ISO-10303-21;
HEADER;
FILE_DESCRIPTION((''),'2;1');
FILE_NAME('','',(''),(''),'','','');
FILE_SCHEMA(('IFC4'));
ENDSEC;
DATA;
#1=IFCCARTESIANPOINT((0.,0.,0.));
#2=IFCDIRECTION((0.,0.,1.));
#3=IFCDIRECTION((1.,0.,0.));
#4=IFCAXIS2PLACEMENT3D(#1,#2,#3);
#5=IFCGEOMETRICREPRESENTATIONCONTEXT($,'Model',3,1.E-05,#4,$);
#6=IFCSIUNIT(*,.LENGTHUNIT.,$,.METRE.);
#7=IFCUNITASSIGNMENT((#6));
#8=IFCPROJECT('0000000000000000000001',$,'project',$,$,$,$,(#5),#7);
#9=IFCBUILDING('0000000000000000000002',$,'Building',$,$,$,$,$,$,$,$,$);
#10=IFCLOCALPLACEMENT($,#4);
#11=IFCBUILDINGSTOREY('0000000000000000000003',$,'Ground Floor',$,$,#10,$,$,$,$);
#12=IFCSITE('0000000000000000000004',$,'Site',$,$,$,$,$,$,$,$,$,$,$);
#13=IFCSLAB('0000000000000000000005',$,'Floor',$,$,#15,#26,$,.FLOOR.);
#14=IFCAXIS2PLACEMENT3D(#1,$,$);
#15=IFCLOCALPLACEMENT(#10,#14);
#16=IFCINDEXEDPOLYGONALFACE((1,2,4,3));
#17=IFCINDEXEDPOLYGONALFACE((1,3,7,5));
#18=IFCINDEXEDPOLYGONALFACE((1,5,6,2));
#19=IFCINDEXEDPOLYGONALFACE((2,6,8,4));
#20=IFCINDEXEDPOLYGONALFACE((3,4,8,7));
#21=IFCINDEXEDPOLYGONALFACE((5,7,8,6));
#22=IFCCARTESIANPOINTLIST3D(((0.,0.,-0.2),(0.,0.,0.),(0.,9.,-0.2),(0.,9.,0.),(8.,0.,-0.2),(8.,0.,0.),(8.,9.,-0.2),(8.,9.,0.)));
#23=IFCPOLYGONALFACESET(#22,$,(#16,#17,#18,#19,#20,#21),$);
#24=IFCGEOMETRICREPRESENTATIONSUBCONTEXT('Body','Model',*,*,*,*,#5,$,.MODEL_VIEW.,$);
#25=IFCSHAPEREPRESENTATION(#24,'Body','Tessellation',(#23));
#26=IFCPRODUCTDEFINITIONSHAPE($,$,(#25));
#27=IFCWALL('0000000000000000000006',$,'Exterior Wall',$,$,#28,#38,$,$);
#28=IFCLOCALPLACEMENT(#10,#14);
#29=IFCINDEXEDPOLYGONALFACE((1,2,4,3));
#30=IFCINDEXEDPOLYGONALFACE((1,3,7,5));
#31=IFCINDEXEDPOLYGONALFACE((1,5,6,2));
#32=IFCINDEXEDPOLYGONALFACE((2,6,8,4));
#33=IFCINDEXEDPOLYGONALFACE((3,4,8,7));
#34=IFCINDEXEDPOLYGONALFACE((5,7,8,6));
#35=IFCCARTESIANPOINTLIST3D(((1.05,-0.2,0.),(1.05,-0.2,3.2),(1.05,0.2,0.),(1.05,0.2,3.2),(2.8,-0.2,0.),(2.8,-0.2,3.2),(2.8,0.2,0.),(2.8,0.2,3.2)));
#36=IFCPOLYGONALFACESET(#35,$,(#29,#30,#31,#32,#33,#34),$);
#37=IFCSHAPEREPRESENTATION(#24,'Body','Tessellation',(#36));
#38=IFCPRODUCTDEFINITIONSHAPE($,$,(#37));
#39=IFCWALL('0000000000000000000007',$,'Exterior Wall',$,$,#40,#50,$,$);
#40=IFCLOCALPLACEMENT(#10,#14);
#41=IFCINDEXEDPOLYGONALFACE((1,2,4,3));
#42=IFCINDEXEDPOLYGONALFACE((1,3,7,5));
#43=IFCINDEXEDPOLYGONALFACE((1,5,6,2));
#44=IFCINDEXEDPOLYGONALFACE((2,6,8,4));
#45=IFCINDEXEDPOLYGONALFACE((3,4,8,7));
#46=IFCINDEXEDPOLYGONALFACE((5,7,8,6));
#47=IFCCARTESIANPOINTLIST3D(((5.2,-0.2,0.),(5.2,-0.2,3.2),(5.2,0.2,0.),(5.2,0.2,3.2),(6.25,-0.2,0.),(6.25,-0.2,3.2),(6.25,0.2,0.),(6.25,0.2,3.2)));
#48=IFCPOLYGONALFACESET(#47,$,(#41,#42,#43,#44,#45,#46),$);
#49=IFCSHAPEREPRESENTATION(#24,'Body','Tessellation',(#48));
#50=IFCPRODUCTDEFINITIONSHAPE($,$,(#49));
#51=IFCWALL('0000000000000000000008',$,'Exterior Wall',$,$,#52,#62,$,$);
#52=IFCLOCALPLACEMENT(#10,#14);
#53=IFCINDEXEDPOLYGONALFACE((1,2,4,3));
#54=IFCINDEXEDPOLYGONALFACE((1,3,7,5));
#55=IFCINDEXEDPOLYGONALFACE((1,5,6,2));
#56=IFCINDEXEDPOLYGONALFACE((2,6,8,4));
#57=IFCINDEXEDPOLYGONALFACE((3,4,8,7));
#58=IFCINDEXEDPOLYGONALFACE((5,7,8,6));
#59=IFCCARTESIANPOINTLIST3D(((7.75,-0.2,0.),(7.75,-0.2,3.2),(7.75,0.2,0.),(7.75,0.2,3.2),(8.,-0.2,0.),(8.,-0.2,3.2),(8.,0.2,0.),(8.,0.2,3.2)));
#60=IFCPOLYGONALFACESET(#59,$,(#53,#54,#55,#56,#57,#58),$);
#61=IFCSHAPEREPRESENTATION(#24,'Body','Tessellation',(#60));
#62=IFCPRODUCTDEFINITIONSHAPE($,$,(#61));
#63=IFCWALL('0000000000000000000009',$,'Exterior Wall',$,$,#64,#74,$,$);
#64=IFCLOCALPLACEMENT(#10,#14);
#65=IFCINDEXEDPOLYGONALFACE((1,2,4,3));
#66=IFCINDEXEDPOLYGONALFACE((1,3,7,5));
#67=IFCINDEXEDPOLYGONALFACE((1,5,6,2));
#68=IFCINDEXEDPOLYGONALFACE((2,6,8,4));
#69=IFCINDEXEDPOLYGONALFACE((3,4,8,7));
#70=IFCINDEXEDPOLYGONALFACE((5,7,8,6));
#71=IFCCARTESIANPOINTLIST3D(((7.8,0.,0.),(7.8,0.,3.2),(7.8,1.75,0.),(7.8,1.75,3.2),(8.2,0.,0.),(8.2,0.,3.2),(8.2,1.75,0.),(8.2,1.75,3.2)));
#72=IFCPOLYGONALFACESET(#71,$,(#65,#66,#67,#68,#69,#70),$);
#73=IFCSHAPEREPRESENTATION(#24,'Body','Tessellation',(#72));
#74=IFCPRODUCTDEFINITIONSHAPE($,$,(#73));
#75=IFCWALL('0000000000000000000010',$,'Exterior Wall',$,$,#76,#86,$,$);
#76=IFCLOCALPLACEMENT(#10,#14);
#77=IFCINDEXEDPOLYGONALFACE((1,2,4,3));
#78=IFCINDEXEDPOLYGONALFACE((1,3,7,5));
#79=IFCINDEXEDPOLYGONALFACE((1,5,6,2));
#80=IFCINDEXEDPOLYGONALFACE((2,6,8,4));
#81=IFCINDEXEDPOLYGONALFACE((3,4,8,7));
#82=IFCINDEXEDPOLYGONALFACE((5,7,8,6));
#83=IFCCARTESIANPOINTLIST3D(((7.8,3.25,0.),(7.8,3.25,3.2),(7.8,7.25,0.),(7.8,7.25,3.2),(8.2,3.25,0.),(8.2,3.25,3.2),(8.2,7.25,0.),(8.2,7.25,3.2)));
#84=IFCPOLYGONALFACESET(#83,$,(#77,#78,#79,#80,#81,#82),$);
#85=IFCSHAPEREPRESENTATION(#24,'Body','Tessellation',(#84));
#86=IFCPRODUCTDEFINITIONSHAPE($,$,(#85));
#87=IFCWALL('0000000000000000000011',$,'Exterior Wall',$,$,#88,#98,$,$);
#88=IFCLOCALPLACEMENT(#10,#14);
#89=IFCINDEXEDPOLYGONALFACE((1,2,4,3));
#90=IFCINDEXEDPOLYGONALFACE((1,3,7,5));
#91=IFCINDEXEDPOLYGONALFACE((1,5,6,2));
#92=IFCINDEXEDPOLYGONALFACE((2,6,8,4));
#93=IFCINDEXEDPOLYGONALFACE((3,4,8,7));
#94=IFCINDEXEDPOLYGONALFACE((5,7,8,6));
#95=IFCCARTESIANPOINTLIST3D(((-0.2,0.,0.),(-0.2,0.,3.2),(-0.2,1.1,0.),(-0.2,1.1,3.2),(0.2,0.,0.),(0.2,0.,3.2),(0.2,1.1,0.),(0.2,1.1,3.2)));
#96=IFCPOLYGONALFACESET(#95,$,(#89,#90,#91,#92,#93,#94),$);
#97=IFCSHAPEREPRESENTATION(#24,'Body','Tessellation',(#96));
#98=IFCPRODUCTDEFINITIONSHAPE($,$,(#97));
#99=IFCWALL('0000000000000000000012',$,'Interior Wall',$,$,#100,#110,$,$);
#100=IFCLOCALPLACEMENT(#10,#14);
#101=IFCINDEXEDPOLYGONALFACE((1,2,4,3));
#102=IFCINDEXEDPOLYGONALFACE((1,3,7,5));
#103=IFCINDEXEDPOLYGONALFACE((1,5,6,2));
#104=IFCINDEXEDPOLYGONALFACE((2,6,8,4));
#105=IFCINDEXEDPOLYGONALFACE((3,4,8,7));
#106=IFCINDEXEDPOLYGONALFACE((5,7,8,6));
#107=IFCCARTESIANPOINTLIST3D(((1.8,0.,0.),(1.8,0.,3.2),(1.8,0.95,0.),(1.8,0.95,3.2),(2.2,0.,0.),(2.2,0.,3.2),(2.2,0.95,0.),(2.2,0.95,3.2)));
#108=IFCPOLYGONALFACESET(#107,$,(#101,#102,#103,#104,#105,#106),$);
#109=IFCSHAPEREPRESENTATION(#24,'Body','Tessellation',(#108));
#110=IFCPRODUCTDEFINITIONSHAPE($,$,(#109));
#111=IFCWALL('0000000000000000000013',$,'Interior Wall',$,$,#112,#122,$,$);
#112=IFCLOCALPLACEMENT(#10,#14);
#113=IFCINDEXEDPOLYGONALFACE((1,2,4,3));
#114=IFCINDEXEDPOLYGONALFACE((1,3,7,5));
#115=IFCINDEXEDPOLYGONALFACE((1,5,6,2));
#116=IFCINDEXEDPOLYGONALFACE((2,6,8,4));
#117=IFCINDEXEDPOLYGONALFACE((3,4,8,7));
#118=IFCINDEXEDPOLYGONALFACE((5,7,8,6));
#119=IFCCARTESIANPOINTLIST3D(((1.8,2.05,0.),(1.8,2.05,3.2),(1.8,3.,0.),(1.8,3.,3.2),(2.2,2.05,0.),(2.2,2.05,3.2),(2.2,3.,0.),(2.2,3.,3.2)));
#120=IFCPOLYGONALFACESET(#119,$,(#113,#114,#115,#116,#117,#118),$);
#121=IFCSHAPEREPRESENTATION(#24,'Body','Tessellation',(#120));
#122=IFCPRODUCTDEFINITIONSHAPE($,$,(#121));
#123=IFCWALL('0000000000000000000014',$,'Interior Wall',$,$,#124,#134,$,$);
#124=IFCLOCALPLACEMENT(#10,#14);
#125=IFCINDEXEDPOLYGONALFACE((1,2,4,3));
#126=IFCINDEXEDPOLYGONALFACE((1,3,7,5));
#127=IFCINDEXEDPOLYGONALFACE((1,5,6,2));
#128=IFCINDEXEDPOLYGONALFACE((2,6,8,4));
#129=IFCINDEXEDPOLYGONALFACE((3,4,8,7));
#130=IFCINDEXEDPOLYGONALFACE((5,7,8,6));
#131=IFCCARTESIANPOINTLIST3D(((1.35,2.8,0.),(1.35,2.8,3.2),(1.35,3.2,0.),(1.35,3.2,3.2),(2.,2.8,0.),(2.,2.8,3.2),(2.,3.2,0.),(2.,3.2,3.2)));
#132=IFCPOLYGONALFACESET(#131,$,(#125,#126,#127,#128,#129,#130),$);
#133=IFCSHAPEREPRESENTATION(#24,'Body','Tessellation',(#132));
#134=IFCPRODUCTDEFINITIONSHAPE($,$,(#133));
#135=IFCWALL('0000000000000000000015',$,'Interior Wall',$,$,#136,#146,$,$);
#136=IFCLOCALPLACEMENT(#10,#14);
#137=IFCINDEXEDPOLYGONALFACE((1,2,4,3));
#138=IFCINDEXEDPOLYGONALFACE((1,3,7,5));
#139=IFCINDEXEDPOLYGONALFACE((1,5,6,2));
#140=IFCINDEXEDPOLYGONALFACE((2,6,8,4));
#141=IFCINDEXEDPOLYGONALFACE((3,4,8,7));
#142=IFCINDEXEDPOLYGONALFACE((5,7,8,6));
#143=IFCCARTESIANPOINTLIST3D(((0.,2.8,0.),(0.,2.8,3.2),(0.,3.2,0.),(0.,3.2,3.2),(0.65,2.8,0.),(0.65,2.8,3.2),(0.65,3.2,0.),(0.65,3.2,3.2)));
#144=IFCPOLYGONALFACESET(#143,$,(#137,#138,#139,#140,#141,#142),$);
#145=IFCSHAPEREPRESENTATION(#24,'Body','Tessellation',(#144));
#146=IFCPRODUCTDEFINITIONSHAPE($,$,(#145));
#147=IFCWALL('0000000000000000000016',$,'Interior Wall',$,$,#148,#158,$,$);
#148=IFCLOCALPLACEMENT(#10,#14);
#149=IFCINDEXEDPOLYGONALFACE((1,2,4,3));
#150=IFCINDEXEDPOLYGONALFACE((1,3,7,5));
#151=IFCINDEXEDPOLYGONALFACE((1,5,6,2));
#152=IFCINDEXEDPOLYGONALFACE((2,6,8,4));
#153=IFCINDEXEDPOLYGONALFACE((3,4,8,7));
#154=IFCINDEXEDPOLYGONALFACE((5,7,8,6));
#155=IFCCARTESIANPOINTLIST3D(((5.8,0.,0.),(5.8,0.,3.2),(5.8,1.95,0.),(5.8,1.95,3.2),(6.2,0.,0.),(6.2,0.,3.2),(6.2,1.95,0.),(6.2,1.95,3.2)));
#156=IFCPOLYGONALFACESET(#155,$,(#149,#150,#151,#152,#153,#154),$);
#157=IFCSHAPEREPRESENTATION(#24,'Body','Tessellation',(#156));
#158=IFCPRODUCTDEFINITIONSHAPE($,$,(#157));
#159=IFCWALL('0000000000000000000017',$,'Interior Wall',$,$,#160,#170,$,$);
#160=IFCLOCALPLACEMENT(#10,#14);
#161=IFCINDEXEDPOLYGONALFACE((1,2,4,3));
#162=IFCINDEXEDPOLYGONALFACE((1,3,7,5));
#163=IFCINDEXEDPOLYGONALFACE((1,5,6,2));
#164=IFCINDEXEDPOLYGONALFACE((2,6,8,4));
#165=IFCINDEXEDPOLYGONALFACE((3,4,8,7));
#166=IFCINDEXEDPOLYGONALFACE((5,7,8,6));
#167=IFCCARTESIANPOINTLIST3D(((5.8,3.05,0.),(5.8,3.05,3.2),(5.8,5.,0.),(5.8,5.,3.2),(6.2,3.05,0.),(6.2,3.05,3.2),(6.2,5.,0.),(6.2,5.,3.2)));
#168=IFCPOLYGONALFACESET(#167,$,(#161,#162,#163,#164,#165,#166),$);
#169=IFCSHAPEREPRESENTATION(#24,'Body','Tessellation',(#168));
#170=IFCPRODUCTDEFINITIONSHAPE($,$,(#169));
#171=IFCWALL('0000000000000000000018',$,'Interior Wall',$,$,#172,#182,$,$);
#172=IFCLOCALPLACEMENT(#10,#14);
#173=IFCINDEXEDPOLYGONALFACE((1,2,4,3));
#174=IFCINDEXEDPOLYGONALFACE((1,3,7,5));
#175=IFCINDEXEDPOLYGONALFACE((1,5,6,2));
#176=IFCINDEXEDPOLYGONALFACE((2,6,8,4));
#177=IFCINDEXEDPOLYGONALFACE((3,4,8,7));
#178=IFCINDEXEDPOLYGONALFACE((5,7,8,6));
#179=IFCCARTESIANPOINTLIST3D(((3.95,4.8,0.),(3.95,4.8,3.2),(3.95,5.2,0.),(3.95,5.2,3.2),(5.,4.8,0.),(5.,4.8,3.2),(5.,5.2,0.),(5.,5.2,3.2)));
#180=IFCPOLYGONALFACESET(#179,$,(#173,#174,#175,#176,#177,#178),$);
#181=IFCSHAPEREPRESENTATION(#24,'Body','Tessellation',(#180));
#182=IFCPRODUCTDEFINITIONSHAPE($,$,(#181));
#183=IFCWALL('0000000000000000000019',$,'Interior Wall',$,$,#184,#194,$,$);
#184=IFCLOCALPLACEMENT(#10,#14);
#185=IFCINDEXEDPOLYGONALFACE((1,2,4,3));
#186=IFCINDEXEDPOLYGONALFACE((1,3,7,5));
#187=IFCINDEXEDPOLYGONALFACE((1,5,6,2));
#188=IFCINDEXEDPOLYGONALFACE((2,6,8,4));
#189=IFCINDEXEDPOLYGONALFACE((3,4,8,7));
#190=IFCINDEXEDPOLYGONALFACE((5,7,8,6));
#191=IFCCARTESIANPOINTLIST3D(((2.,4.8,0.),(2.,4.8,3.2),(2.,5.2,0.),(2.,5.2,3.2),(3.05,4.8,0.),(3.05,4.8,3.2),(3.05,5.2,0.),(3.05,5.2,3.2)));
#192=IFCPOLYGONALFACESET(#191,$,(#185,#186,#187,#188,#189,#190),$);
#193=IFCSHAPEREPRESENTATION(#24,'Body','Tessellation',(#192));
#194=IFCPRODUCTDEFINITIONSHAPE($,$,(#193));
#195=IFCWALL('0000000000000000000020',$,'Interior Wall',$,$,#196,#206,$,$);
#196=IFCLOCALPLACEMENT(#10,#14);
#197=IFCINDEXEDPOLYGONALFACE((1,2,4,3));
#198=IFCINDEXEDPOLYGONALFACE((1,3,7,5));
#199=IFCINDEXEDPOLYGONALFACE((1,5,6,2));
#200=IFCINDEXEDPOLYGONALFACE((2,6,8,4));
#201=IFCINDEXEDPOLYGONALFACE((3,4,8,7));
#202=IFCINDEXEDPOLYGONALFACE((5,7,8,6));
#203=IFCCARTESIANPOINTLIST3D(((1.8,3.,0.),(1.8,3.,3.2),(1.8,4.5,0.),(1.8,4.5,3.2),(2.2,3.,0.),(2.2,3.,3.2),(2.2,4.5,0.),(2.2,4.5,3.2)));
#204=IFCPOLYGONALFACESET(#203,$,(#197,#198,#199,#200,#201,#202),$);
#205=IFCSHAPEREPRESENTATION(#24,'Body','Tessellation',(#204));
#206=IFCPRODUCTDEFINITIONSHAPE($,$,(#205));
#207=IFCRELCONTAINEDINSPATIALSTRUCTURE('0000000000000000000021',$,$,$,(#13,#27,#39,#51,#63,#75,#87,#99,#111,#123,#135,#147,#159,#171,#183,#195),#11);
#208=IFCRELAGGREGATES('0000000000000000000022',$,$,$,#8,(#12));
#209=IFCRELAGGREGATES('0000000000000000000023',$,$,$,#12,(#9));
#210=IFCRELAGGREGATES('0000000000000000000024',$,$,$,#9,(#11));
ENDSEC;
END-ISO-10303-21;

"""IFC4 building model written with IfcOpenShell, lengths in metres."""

from ifc_helpers import new_model, si_unit, frame, origin_with_axes, place, context, subcontext, project, spatial, indexed_curve, outline, extrude, element, save


model = new_model("IFC4")

# Units and contexts
model_context = context("Model", 3, precision=1e-05, world=origin_with_axes())
body_context = subcontext(model_context, "Body", "Model", "MODEL_VIEW")
ifc_project = project(units=[si_unit("LENGTHUNIT", "METRE")], contexts=[model_context])

# Site, building, storey
site = spatial("IfcSite", under=ifc_project, Name="Site")
building = spatial("IfcBuilding", under=site, Name="Building")
storey_placement = place(None, origin_with_axes())
storey = spatial("IfcBuildingStorey", under=building, at=storey_placement, Name="Ground Floor")

# Slab
slab_placement = place(storey_placement, frame((0.0, 0.0, -0.2), z_axis=(0.0, 0.0, 1.0), x_axis=(1.0, 0.0, 0.0)))
element("IfcSlab", 1, at=slab_placement, inside=storey, Name="Floor", PredefinedType="FLOOR", context=body_context, shape_type="SweptSolid", body=[
    extrude(outline(indexed_curve([(0.0, 0.0), (8.0, 0.0), (8.0, 9.0), (0.0, 9.0)])), None, (0.0, 0.0, 1.0), 0.2),
])

# Walls
wall_1_placement = place(storey_placement, frame((1.05, 0.0, 0.0), z_axis=(0.0, 0.0, 1.0), x_axis=(1.0, 0.0, 0.0)))
element("IfcWall", 2, at=wall_1_placement, inside=storey, Name="Exterior Wall", context=body_context, shape_type="SweptSolid", body=[
    extrude(outline(indexed_curve([(0.0, 0.0), (0.0, 0.4), (1.75, 0.4), (1.75, 0.0), (0.0, 0.0)], self_intersect=False)), frame((0.0, -0.2, 0.0), z_axis=(0.0, 0.0, 1.0), x_axis=(1.0, 0.0, 0.0)), (0.0, 0.0, 1.0), 3.2),
])
wall_2_placement = place(storey_placement, frame((5.2, 0.0, 0.0), z_axis=(0.0, 0.0, 1.0), x_axis=(1.0, 0.0, 0.0)))
element("IfcWall", 3, at=wall_2_placement, inside=storey, Name="Exterior Wall", context=body_context, shape_type="SweptSolid", body=[
    extrude(outline(indexed_curve([(0.0, 0.0), (0.0, 0.4), (1.05, 0.4), (1.05, 0.0), (0.0, 0.0)], self_intersect=False)), frame((0.0, -0.2, 0.0), z_axis=(0.0, 0.0, 1.0), x_axis=(1.0, 0.0, 0.0)), (0.0, 0.0, 1.0), 3.2),
])
wall_3_placement = place(storey_placement, frame((7.75, 0.0, 0.0), z_axis=(0.0, 0.0, 1.0), x_axis=(1.0, 0.0, 0.0)))
element("IfcWall", 4, at=wall_3_placement, inside=storey, Name="Exterior Wall", context=body_context, shape_type="SweptSolid", body=[
    extrude(outline(indexed_curve([(0.0, 0.0), (0.0, 0.4), (0.25, 0.4), (0.25, 0.0), (0.0, 0.0)], self_intersect=False)), frame((0.0, -0.2, 0.0), z_axis=(0.0, 0.0, 1.0), x_axis=(1.0, 0.0, 0.0)), (0.0, 0.0, 1.0), 3.2),
])
wall_4_placement = place(storey_placement, frame((8.0, 0.0, 0.0), z_axis=(0.0, 0.0, 1.0), x_axis=(0.0, 1.0, 0.0)))
element("IfcWall", 5, at=wall_4_placement, inside=storey, Name="Exterior Wall", context=body_context, shape_type="SweptSolid", body=[
    extrude(outline(indexed_curve([(0.0, 0.0), (0.0, 0.4), (1.75, 0.4), (1.75, 0.0), (0.0, 0.0)], self_intersect=False)), frame((0.0, -0.2, 0.0), z_axis=(0.0, 0.0, 1.0), x_axis=(1.0, 0.0, 0.0)), (0.0, 0.0, 1.0), 3.2),
])
wall_5_placement = place(storey_placement, frame((8.0, 3.25, 0.0), z_axis=(0.0, 0.0, 1.0), x_axis=(0.0, 1.0, 0.0)))
element("IfcWall", 6, at=wall_5_placement, inside=storey, Name="Exterior Wall", context=body_context, shape_type="SweptSolid", body=[
    extrude(outline(indexed_curve([(0.0, 0.0), (0.0, 0.4), (4.0, 0.4), (4.0, 0.0), (0.0, 0.0)], self_intersect=False)), frame((0.0, -0.2, 0.0), z_axis=(0.0, 0.0, 1.0), x_axis=(1.0, 0.0, 0.0)), (0.0, 0.0, 1.0), 3.2),
])
wall_6_placement = place(storey_placement, frame((0.0, 1.1, 0.0), z_axis=(0.0, 0.0, 1.0), x_axis=(0.0, -1.0, 0.0)))
element("IfcWall", 7, at=wall_6_placement, inside=storey, Name="Exterior Wall", context=body_context, shape_type="SweptSolid", body=[
    extrude(outline(indexed_curve([(0.0, 0.0), (0.0, 0.4), (1.1, 0.4), (1.1, 0.0), (0.0, 0.0)], self_intersect=False)), frame((0.0, -0.2, 0.0), z_axis=(0.0, 0.0, 1.0), x_axis=(1.0, 0.0, 0.0)), (0.0, 0.0, 1.0), 3.2),
])
wall_7_placement = place(storey_placement, frame((2.0, 0.0, 0.0), z_axis=(0.0, 0.0, 1.0), x_axis=(0.0, 1.0, 0.0)))
element("IfcWall", 8, at=wall_7_placement, inside=storey, Name="Interior Wall", context=body_context, shape_type="SweptSolid", body=[
    extrude(outline(indexed_curve([(0.0, 0.0), (0.0, 0.4), (0.95, 0.4), (0.95, 0.0), (0.0, 0.0)], self_intersect=False)), frame((0.0, -0.2, 0.0), z_axis=(0.0, 0.0, 1.0), x_axis=(1.0, 0.0, 0.0)), (0.0, 0.0, 1.0), 3.2),
])
wall_8_placement = place(storey_placement, frame((2.0, 2.05, 0.0), z_axis=(0.0, 0.0, 1.0), x_axis=(0.0, 1.0, 0.0)))
element("IfcWall", 9, at=wall_8_placement, inside=storey, Name="Interior Wall", context=body_context, shape_type="SweptSolid", body=[
    extrude(outline(indexed_curve([(0.0, 0.0), (0.0, 0.4), (0.95, 0.4), (0.95, 0.0), (0.0, 0.0)], self_intersect=False)), frame((0.0, -0.2, 0.0), z_axis=(0.0, 0.0, 1.0), x_axis=(1.0, 0.0, 0.0)), (0.0, 0.0, 1.0), 3.2),
])
for number, where, z_axis, x_axis, name in (
    (10, (2.0, 3.0, 0.0), (0.0, 0.0, 1.0), (-1.0, 0.0, 0.0), "Interior Wall"),
    (11, (0.65, 3.0, 0.0), (0.0, 0.0, 1.0), (-1.0, 0.0, 0.0), "Interior Wall"),
):
    element("IfcWall", number, at=place(storey_placement, frame(where, z_axis=z_axis, x_axis=x_axis)), inside=storey, Name=name, context=body_context, shape_type="SweptSolid", body=[
        extrude(outline(indexed_curve([(0.0, 0.0), (0.0, 0.4), (0.65, 0.4), (0.65, 0.0), (0.0, 0.0)], self_intersect=False)), frame((0.0, -0.2, 0.0), z_axis=(0.0, 0.0, 1.0), x_axis=(1.0, 0.0, 0.0)), (0.0, 0.0, 1.0), 3.2),
    ])
wall_9_placement = place(storey_placement, frame((6.0, 0.0, 0.0), z_axis=(0.0, 0.0, 1.0), x_axis=(0.0, 1.0, 0.0)))
element("IfcWall", 12, at=wall_9_placement, inside=storey, Name="Interior Wall", context=body_context, shape_type="SweptSolid", body=[
    extrude(outline(indexed_curve([(0.0, 0.0), (0.0, 0.4), (1.95, 0.4), (1.95, 0.0), (0.0, 0.0)], self_intersect=False)), frame((0.0, -0.2, 0.0), z_axis=(0.0, 0.0, 1.0), x_axis=(1.0, 0.0, 0.0)), (0.0, 0.0, 1.0), 3.2),
])
wall_10_placement = place(storey_placement, frame((6.0, 3.05, 0.0), z_axis=(0.0, 0.0, 1.0), x_axis=(0.0, 1.0, 0.0)))
element("IfcWall", 13, at=wall_10_placement, inside=storey, Name="Interior Wall", context=body_context, shape_type="SweptSolid", body=[
    extrude(outline(indexed_curve([(0.0, 0.0), (0.0, 0.4), (1.95, 0.4), (1.95, 0.0), (0.0, 0.0)], self_intersect=False)), frame((0.0, -0.2, 0.0), z_axis=(0.0, 0.0, 1.0), x_axis=(1.0, 0.0, 0.0)), (0.0, 0.0, 1.0), 3.2),
])
for number, where, z_axis, x_axis, name in (
    (14, (5.0, 5.0, 0.0), (0.0, 0.0, 1.0), (-1.0, 0.0, 0.0), "Interior Wall"),
    (15, (3.05, 5.0, 0.0), (0.0, 0.0, 1.0), (-1.0, 0.0, 0.0), "Interior Wall"),
):
    element("IfcWall", number, at=place(storey_placement, frame(where, z_axis=z_axis, x_axis=x_axis)), inside=storey, Name=name, context=body_context, shape_type="SweptSolid", body=[
        extrude(outline(indexed_curve([(0.0, 0.0), (0.0, 0.4), (1.05, 0.4), (1.05, 0.0), (0.0, 0.0)], self_intersect=False)), frame((0.0, -0.2, 0.0), z_axis=(0.0, 0.0, 1.0), x_axis=(1.0, 0.0, 0.0)), (0.0, 0.0, 1.0), 3.2),
    ])
wall_11_placement = place(storey_placement, frame((2.0, 4.5, 0.0), z_axis=(0.0, 0.0, 1.0), x_axis=(0.0, -1.0, 0.0)))
element("IfcWall", 16, at=wall_11_placement, inside=storey, Name="Interior Wall", context=body_context, shape_type="SweptSolid", body=[
    extrude(outline(indexed_curve([(0.0, 0.0), (0.0, 0.4), (1.5, 0.4), (1.5, 0.0), (0.0, 0.0)], self_intersect=False)), frame((0.0, -0.2, 0.0), z_axis=(0.0, 0.0, 1.0), x_axis=(1.0, 0.0, 0.0)), (0.0, 0.0, 1.0), 3.2),
])

save(model, "model.ifc")
